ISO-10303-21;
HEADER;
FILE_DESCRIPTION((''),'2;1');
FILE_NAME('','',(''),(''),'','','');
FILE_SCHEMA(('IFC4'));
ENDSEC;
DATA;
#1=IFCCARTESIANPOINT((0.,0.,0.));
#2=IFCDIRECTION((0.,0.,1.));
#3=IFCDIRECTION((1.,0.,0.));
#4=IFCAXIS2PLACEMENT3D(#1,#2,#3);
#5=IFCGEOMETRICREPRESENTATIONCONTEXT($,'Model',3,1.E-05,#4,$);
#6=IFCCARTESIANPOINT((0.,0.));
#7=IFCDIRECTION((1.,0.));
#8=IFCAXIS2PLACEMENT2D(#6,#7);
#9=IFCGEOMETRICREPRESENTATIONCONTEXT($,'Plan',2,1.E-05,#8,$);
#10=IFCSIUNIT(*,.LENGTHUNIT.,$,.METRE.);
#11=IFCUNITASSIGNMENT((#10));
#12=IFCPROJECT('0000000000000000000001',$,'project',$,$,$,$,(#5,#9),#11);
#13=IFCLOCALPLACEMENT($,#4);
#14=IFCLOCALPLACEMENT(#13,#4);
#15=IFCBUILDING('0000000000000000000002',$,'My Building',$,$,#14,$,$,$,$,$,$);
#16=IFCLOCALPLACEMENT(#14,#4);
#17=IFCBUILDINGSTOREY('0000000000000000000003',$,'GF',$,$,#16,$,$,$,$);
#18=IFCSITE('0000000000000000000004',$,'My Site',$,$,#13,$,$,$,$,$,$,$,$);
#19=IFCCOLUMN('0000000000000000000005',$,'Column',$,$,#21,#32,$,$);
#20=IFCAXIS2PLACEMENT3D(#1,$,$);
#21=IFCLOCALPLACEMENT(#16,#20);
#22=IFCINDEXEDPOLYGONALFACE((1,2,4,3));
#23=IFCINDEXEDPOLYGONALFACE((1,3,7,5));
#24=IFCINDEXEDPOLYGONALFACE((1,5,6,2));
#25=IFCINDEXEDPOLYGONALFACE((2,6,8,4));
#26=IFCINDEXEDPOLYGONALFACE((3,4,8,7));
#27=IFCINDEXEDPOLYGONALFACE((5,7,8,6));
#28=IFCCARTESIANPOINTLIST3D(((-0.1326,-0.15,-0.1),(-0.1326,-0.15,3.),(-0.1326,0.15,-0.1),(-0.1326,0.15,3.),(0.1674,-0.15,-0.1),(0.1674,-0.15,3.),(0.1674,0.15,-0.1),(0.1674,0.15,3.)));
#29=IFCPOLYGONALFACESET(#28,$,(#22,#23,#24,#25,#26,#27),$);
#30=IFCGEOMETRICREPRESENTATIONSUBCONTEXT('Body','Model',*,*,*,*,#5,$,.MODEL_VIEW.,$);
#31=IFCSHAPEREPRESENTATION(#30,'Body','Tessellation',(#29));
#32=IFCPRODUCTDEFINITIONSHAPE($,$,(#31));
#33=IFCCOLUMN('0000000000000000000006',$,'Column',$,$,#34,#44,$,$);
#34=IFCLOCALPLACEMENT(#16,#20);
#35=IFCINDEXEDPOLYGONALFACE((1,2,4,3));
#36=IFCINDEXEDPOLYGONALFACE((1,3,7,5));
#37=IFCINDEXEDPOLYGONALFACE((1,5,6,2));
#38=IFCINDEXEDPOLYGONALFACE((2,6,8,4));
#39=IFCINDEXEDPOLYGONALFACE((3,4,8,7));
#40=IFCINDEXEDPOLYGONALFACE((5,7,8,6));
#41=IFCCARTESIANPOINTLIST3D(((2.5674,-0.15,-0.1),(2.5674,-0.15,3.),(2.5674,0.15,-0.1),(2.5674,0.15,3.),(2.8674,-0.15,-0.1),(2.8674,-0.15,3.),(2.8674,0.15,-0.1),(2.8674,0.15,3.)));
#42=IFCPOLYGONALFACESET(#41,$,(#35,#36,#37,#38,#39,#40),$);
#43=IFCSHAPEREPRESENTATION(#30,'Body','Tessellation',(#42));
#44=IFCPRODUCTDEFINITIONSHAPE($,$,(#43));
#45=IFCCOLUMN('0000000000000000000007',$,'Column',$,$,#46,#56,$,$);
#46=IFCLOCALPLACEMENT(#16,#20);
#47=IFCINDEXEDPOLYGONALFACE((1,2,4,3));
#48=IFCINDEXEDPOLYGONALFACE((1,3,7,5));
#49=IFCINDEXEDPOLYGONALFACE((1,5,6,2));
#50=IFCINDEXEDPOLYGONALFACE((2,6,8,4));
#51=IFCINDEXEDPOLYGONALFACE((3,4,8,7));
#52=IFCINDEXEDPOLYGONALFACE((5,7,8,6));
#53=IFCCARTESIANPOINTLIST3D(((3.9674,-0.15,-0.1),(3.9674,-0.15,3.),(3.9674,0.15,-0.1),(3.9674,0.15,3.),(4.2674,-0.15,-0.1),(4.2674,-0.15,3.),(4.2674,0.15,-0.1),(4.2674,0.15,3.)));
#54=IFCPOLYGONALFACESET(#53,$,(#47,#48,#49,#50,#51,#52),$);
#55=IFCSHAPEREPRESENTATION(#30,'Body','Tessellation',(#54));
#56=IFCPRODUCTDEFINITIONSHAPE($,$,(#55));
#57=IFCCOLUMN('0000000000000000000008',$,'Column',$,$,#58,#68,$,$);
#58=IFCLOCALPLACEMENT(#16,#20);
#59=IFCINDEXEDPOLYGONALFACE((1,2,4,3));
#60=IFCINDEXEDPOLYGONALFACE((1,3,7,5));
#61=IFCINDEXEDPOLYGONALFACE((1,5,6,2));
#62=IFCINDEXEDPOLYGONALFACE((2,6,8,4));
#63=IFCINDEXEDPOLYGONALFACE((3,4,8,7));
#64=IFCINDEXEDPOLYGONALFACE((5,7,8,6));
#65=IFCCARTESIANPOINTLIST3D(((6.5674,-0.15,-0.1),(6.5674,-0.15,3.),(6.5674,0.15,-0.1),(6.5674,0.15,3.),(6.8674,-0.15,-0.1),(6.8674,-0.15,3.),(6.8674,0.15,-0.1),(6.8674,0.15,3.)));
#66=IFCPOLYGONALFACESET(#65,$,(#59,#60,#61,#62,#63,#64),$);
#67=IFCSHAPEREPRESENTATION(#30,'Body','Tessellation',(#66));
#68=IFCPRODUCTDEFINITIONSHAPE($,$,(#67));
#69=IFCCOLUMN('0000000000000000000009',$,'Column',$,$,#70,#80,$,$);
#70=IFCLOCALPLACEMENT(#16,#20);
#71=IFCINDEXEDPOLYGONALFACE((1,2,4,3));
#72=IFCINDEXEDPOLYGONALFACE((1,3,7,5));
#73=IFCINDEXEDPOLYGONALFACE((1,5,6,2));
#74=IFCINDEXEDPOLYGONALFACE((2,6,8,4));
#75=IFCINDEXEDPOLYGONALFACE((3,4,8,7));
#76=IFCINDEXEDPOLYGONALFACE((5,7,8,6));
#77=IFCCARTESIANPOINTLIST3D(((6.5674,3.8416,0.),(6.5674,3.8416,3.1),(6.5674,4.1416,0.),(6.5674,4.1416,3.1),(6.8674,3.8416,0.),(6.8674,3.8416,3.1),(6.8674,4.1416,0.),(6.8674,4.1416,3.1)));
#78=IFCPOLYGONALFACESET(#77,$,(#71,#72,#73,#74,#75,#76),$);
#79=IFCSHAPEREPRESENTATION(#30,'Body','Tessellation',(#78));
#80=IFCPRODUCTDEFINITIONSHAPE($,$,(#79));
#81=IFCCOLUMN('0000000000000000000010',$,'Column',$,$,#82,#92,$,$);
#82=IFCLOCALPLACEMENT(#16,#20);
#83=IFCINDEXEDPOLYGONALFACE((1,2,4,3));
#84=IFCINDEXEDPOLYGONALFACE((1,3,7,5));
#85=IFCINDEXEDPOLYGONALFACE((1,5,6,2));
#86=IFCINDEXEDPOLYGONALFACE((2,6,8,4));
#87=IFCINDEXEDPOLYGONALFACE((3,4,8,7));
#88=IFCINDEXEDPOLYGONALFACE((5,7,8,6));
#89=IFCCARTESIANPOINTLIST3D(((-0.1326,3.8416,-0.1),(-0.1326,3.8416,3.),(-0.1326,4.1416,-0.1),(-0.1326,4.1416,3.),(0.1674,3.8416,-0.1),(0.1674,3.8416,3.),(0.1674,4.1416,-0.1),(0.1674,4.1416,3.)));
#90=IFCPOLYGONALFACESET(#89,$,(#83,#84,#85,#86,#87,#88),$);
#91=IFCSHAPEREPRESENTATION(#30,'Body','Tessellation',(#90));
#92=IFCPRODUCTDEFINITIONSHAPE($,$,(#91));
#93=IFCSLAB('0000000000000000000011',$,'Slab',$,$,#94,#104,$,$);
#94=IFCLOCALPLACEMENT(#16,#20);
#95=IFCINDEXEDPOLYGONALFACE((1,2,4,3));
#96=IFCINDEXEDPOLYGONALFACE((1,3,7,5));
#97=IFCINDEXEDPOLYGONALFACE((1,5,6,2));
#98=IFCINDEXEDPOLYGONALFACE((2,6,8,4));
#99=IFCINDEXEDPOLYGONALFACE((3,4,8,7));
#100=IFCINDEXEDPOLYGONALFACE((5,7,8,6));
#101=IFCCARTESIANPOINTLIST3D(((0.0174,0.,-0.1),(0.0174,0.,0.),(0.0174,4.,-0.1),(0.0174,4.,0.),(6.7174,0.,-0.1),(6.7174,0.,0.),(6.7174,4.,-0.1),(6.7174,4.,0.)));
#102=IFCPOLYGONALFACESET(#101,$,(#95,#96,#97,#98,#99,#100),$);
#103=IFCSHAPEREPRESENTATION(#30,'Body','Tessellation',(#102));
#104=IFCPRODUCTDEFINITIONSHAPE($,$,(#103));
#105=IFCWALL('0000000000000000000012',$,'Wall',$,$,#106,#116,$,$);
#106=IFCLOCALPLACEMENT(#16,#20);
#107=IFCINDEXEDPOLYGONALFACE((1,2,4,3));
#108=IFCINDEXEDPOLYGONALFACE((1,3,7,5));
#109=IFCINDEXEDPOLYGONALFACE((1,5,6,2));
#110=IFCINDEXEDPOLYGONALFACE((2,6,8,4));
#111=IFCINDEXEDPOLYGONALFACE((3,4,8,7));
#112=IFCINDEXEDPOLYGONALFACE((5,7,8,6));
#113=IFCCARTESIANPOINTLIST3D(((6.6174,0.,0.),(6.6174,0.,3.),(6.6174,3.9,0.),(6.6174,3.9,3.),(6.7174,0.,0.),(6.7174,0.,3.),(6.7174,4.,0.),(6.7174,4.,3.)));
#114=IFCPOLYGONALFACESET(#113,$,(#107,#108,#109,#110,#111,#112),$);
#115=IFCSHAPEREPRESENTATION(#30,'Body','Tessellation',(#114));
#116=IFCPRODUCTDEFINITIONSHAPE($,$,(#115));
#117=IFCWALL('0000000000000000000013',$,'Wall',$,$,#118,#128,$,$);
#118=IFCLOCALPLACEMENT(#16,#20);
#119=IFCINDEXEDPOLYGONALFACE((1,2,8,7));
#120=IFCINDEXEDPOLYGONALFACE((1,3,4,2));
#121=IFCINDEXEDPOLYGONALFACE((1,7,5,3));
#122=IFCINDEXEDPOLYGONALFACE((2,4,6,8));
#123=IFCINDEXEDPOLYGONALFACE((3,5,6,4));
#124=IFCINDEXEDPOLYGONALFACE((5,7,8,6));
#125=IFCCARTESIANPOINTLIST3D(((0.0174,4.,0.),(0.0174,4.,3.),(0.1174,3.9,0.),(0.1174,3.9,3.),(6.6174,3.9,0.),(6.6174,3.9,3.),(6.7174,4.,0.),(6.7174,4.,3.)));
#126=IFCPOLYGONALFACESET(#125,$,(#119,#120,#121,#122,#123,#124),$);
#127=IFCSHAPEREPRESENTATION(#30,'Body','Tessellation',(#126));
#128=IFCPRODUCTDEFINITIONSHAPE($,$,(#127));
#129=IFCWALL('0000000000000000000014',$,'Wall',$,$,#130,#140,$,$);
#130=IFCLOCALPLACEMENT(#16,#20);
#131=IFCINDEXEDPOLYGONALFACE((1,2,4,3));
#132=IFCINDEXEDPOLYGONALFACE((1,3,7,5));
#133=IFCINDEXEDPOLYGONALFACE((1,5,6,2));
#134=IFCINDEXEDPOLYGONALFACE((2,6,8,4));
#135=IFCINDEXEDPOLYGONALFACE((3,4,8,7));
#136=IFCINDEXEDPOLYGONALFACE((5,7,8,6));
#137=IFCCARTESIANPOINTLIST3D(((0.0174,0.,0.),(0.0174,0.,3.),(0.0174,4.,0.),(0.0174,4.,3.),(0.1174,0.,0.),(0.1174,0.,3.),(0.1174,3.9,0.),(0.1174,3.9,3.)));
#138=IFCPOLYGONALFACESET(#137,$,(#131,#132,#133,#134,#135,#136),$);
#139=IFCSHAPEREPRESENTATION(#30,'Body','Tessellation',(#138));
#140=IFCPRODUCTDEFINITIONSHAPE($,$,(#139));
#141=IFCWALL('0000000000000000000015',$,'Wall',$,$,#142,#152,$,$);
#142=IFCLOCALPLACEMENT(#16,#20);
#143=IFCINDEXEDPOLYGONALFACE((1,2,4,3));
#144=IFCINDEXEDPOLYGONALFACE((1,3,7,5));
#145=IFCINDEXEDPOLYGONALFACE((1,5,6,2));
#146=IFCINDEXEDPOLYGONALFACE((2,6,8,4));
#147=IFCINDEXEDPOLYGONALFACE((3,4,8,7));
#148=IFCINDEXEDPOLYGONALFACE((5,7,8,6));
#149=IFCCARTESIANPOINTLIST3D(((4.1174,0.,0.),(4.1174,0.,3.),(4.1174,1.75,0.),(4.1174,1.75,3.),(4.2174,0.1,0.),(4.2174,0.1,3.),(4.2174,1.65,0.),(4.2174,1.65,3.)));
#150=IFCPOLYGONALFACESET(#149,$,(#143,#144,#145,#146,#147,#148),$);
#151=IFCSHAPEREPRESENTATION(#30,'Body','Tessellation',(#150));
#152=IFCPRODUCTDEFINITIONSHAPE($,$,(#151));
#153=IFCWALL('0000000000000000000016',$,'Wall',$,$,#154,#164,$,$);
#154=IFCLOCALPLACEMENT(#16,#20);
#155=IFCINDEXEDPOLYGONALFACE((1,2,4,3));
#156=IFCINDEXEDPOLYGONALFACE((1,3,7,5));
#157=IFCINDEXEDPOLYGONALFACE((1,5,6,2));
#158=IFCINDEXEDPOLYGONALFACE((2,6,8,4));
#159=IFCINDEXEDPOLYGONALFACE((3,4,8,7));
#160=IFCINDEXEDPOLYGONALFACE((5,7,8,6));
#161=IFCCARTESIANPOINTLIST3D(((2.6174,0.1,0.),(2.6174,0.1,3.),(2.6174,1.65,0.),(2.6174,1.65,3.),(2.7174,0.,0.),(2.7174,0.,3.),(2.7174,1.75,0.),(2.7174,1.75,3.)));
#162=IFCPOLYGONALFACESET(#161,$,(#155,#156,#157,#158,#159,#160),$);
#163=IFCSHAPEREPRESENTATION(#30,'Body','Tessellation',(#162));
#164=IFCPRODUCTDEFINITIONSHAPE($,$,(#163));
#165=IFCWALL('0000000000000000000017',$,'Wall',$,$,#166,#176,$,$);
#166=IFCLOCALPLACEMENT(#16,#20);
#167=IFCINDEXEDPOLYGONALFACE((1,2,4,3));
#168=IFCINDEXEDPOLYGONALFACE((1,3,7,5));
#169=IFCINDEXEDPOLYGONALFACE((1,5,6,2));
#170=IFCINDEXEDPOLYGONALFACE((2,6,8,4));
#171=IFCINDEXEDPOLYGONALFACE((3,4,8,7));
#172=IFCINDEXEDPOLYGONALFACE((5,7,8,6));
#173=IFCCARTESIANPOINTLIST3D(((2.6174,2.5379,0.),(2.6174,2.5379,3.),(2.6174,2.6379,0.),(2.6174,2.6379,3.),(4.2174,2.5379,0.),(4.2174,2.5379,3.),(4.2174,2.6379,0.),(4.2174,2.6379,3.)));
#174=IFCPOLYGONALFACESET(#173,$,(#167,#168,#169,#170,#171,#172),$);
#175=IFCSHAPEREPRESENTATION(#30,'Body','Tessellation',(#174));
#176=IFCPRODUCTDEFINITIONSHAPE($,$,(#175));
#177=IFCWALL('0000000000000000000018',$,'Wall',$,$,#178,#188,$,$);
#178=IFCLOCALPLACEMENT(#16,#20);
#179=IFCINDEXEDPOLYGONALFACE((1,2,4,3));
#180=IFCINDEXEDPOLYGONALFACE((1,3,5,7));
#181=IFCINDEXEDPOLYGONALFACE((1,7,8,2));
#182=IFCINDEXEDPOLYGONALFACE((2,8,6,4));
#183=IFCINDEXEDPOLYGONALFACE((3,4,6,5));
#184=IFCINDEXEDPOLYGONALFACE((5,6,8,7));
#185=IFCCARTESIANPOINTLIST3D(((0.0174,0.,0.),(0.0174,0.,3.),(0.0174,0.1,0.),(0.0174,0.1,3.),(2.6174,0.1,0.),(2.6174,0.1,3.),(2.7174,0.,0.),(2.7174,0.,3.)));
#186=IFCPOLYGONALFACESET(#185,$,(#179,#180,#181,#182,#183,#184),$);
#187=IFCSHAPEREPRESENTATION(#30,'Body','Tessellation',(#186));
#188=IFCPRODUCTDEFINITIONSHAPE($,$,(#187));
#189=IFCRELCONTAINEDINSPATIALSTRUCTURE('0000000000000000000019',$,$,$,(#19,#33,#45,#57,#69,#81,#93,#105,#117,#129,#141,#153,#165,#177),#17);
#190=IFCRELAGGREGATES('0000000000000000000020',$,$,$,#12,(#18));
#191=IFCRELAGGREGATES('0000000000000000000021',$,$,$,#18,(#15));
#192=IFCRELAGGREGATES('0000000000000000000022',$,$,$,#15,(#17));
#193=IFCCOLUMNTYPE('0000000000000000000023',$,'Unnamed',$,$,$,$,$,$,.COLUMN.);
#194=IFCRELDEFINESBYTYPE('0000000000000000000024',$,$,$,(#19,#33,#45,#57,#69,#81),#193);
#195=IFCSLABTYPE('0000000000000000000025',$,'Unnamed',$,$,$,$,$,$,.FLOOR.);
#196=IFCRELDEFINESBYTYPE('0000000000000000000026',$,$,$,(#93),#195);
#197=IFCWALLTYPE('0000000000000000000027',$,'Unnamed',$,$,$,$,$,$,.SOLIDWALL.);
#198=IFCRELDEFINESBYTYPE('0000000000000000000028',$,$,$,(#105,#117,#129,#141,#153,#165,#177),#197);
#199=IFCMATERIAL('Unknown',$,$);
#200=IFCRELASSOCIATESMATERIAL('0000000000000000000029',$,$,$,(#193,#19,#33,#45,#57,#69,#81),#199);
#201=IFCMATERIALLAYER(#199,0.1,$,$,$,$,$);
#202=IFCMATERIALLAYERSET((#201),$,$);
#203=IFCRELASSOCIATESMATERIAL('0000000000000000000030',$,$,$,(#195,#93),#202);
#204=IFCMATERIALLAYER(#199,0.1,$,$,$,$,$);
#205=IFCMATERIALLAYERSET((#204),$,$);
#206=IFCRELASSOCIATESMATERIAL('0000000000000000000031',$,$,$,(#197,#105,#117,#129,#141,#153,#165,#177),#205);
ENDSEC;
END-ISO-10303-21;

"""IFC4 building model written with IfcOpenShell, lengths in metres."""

from ifc_helpers import new_model, si_unit, frame, origin_with_axes, origin_2d_with_axis, place, context, subcontext, project, spatial, line, indexed_curve, rectangle, outline, extrude, material, layer, layer_set, layer_usage, material_profile, profile_set, profile_usage, type_object, element, save


model = new_model("IFC4")

# Units and contexts
model_context = context("Model", 3, precision=1e-05, world=origin_with_axes())
plan_context = context("Plan", 2, precision=1e-05, world=origin_2d_with_axis())
body_context_1 = subcontext(model_context, "Body", "Model", "MODEL_VIEW")
ifc_project = project(units=[si_unit("LENGTHUNIT", "METRE")], contexts=[model_context, plan_context])

# Site, building, storey
site_placement = place(None, origin_with_axes())
site = spatial("IfcSite", under=ifc_project, at=site_placement, Name="My Site")
building_placement = place(site_placement, origin_with_axes())
building = spatial("IfcBuilding", under=site, at=building_placement, Name="My Building")
storey_placement = place(building_placement, origin_with_axes())
storey = spatial("IfcBuildingStorey", under=building, at=storey_placement, Name="GF")

# Columns
ifc_material = material(Name="Unknown")
ifc_material_profile = material_profile(ifc_material, rectangle(XDim=0.3, YDim=0.3))
ifc_profile_set = profile_set([ifc_material_profile])
ifc_profile_usage_1 = profile_usage(ifc_profile_set, cardinal=5)
column_type = type_object("IfcColumnType", Name="Unnamed", PredefinedType="COLUMN", material=ifc_profile_set)
column_1_placement = place(storey_placement, frame((0.0174, 0.0, -0.1), z_axis=(0.0, 0.0, 1.0), x_axis=(1.0, 0.0, 0.0)))
element("IfcColumn", 1, at=column_1_placement, inside=storey, type_object=column_type, material=ifc_profile_usage_1, Name="Column", context=body_context_1, shape_type="SweptSolid", body=[
    extrude(rectangle(XDim=0.3, YDim=0.3), origin_with_axes(), (0.0, 0.0, 1.0), 3.1),
])
ifc_profile_usage_2 = profile_usage(ifc_profile_set, cardinal=5)
column_2_placement = place(storey_placement, frame((2.7174, 0.0, -0.1), z_axis=(0.0, 0.0, 1.0), x_axis=(1.0, 0.0, 0.0)))
element("IfcColumn", 2, at=column_2_placement, inside=storey, type_object=column_type, material=ifc_profile_usage_2, Name="Column", context=body_context_1, shape_type="SweptSolid", body=[
    extrude(rectangle(XDim=0.3, YDim=0.3), origin_with_axes(), (0.0, 0.0, 1.0), 3.1),
])
ifc_profile_usage_3 = profile_usage(ifc_profile_set, cardinal=5)
column_3_placement = place(storey_placement, frame((4.1174, 0.0, -0.1), z_axis=(0.0, 0.0, 1.0), x_axis=(1.0, 0.0, 0.0)))
element("IfcColumn", 3, at=column_3_placement, inside=storey, type_object=column_type, material=ifc_profile_usage_3, Name="Column", context=body_context_1, shape_type="SweptSolid", body=[
    extrude(rectangle(XDim=0.3, YDim=0.3), origin_with_axes(), (0.0, 0.0, 1.0), 3.1),
])
ifc_profile_usage_4 = profile_usage(ifc_profile_set, cardinal=5)
column_4_placement = place(storey_placement, frame((6.7174, 0.0, -0.1), z_axis=(0.0, 0.0, 1.0), x_axis=(1.0, 0.0, 0.0)))
element("IfcColumn", 4, at=column_4_placement, inside=storey, type_object=column_type, material=ifc_profile_usage_4, Name="Column", context=body_context_1, shape_type="SweptSolid", body=[
    extrude(rectangle(XDim=0.3, YDim=0.3), origin_with_axes(), (0.0, 0.0, 1.0), 3.1),
])
ifc_profile_usage_5 = profile_usage(ifc_profile_set, cardinal=5)
column_5_placement = place(storey_placement, frame((6.7174, 3.9916, 0.0), z_axis=(0.0, 0.0, 1.0), x_axis=(1.0, 0.0, 0.0)))
element("IfcColumn", 5, at=column_5_placement, inside=storey, type_object=column_type, material=ifc_profile_usage_5, Name="Column", context=body_context_1, shape_type="SweptSolid", body=[
    extrude(rectangle(XDim=0.3, YDim=0.3), origin_with_axes(), (0.0, 0.0, 1.0), 3.1),
])
ifc_profile_usage_6 = profile_usage(ifc_profile_set, cardinal=5)
column_6_placement = place(storey_placement, frame((0.0174, 3.9916, -0.1), z_axis=(0.0, 0.0, 1.0), x_axis=(1.0, 0.0, 0.0)))
element("IfcColumn", 6, at=column_6_placement, inside=storey, type_object=column_type, material=ifc_profile_usage_6, Name="Column", context=body_context_1, shape_type="SweptSolid", body=[
    extrude(rectangle(XDim=0.3, YDim=0.3), origin_with_axes(), (0.0, 0.0, 1.0), 3.1),
])

# Slab
ifc_layer_1 = layer(ifc_material, 0.1)
ifc_layer_set_1 = layer_set([ifc_layer_1])
ifc_layer_usage_1 = layer_usage(ifc_layer_set_1, "AXIS3", "POSITIVE", -0.1)
slab_type = type_object("IfcSlabType", Name="Unnamed", PredefinedType="FLOOR", material=ifc_layer_set_1)
slab_placement = place(storey_placement, frame((0.0, 4.0, 0.0), z_axis=(0.0, 0.0, 1.0), x_axis=(1.0, 0.0, 0.0)))
element("IfcSlab", 7, at=slab_placement, inside=storey, type_object=slab_type, material=ifc_layer_usage_1, Name="Slab", context=body_context_1, shape_type="SweptSolid", body=[
    extrude(outline(indexed_curve([(0.0, 0.0), (6.7174, 0.0), (6.7174, -4.0), (0.0174, -4.0), (0.0174, 0.0), (0.0, 0.0)])), frame((0.0, 0.0, -0.1), z_axis=(0.0, 0.0, 1.0), x_axis=(1.0, 0.0, 0.0)), (0.0, 0.0, 1.0), 0.1),
])

# Walls
ifc_layer_2 = layer(ifc_material, 0.1)
ifc_layer_set_2 = layer_set([ifc_layer_2])
ifc_layer_usage_2 = layer_usage(ifc_layer_set_2, "AXIS2", "POSITIVE", 0.0)
wall_type = type_object("IfcWallType", Name="Unnamed", PredefinedType="SOLIDWALL", material=ifc_layer_set_2)
wall_1_placement = place(storey_placement, frame((6.7174, 0.0, 0.0), z_axis=(0.0, 0.0, 1.0), x_axis=(0.0, 1.0, 0.0)))
element("IfcWall", 8, at=wall_1_placement, inside=storey, type_object=wall_type, material=ifc_layer_usage_2, Name="Wall", context=body_context_1, shape_type="SweptSolid", body=[
    extrude(outline(indexed_curve([(0.0, 0.0), (0.0, 0.1), (3.9, 0.1), (4.0, 0.0)], segments=[line(1, 2, 3, 4, 1)])), origin_with_axes(), (0.0, 0.0, 1.0), 3.0),
])
ifc_layer_usage_3 = layer_usage(ifc_layer_set_2, "AXIS2", "POSITIVE", 0.0)
wall_2_placement = place(storey_placement, frame((6.7174, 4.0, 0.0), z_axis=(0.0, 0.0, 1.0), x_axis=(-1.0, 0.0, 0.0)))
element("IfcWall", 9, at=wall_2_placement, inside=storey, type_object=wall_type, material=ifc_layer_usage_3, Name="Wall", context=body_context_1, shape_type="SweptSolid", body=[
    extrude(outline(indexed_curve([(0.0, 0.0), (0.1, 0.1), (6.6, 0.1), (6.7, 0.0)], segments=[line(1, 2, 3, 4, 1)])), origin_with_axes(), (0.0, 0.0, 1.0), 3.0),
])
ifc_layer_usage_4 = layer_usage(ifc_layer_set_2, "AXIS2", "POSITIVE", 0.0)
wall_3_placement = place(storey_placement, frame((0.0174, 4.0, 0.0), z_axis=(0.0, 0.0, 1.0), x_axis=(0.0, -1.0, 0.0)))
element("IfcWall", 10, at=wall_3_placement, inside=storey, type_object=wall_type, material=ifc_layer_usage_4, Name="Wall", context=body_context_1, shape_type="SweptSolid", body=[
    extrude(outline(indexed_curve([(0.0, 0.0), (0.1, 0.1), (4.0, 0.1), (4.0, 0.0)], segments=[line(1, 2, 3, 4, 1)])), origin_with_axes(), (0.0, 0.0, 1.0), 3.0),
])
ifc_layer_usage_5 = layer_usage(ifc_layer_set_2, "AXIS2", "POSITIVE", 0.0)
wall_4_placement = place(storey_placement, frame((4.1174, 1.75, 0.0), z_axis=(0.0, 0.0, 1.0), x_axis=(0.0, -1.0, 0.0)))
element("IfcWall", 11, at=wall_4_placement, inside=storey, type_object=wall_type, material=ifc_layer_usage_5, Name="Wall", context=body_context_1, shape_type="SweptSolid", body=[
    extrude(outline(indexed_curve([(0.0, 0.0), (0.1, 0.1), (1.65, 0.1), (1.75, 0.0)], segments=[line(1, 2, 3, 4, 1)])), origin_with_axes(), (0.0, 0.0, 1.0), 3.0),
])
ifc_layer_usage_6 = layer_usage(ifc_layer_set_2, "AXIS2", "POSITIVE", 0.0)
wall_5_placement = place(storey_placement, frame((2.6174, 1.75, 0.0), z_axis=(0.0, 0.0, 1.0), x_axis=(0.0, -1.0, 0.0)))
element("IfcWall", 12, at=wall_5_placement, inside=storey, type_object=wall_type, material=ifc_layer_usage_6, Name="Wall", context=body_context_1, shape_type="SweptSolid", body=[
    extrude(outline(indexed_curve([(0.1, 0.0), (0.0, 0.1), (1.75, 0.1), (1.65, 0.0)], segments=[line(1, 2, 3, 4, 1)])), origin_with_axes(), (0.0, 0.0, 1.0), 3.0),
])
ifc_layer_usage_7 = layer_usage(ifc_layer_set_2, "AXIS2", "POSITIVE", 0.0)
wall_6_placement = place(storey_placement, frame((2.6174, 2.5379, 0.0), z_axis=(0.0, 0.0, 1.0), x_axis=(1.0, 0.0, 0.0)))
element("IfcWall", 13, at=wall_6_placement, inside=storey, type_object=wall_type, material=ifc_layer_usage_7, Name="Wall", context=body_context_1, shape_type="SweptSolid", body=[
    extrude(outline(indexed_curve([(0.0, 0.0), (0.0, 0.1), (1.6, 0.1), (1.6, 0.0)], segments=[line(1, 2, 3, 4, 1)])), origin_with_axes(), (0.0, 0.0, 1.0), 3.0),
])
ifc_layer_usage_8 = layer_usage(ifc_layer_set_2, "AXIS2", "POSITIVE", 0.0)
wall_7_placement = place(storey_placement, frame((0.0174, 0.0, 0.0), z_axis=(0.0, 0.0, 1.0), x_axis=(1.0, 0.0, 0.0)))
element("IfcWall", 14, at=wall_7_placement, inside=storey, type_object=wall_type, material=ifc_layer_usage_8, Name="Wall", context=body_context_1, shape_type="SweptSolid", body=[
    extrude(outline(indexed_curve([(0.0, 0.0), (0.0, 0.1), (2.6, 0.1), (2.7, 0.0)], segments=[line(1, 2, 3, 4, 1)])), origin_with_axes(), (0.0, 0.0, 1.0), 3.0),
])

save(model, "model.ifc")
